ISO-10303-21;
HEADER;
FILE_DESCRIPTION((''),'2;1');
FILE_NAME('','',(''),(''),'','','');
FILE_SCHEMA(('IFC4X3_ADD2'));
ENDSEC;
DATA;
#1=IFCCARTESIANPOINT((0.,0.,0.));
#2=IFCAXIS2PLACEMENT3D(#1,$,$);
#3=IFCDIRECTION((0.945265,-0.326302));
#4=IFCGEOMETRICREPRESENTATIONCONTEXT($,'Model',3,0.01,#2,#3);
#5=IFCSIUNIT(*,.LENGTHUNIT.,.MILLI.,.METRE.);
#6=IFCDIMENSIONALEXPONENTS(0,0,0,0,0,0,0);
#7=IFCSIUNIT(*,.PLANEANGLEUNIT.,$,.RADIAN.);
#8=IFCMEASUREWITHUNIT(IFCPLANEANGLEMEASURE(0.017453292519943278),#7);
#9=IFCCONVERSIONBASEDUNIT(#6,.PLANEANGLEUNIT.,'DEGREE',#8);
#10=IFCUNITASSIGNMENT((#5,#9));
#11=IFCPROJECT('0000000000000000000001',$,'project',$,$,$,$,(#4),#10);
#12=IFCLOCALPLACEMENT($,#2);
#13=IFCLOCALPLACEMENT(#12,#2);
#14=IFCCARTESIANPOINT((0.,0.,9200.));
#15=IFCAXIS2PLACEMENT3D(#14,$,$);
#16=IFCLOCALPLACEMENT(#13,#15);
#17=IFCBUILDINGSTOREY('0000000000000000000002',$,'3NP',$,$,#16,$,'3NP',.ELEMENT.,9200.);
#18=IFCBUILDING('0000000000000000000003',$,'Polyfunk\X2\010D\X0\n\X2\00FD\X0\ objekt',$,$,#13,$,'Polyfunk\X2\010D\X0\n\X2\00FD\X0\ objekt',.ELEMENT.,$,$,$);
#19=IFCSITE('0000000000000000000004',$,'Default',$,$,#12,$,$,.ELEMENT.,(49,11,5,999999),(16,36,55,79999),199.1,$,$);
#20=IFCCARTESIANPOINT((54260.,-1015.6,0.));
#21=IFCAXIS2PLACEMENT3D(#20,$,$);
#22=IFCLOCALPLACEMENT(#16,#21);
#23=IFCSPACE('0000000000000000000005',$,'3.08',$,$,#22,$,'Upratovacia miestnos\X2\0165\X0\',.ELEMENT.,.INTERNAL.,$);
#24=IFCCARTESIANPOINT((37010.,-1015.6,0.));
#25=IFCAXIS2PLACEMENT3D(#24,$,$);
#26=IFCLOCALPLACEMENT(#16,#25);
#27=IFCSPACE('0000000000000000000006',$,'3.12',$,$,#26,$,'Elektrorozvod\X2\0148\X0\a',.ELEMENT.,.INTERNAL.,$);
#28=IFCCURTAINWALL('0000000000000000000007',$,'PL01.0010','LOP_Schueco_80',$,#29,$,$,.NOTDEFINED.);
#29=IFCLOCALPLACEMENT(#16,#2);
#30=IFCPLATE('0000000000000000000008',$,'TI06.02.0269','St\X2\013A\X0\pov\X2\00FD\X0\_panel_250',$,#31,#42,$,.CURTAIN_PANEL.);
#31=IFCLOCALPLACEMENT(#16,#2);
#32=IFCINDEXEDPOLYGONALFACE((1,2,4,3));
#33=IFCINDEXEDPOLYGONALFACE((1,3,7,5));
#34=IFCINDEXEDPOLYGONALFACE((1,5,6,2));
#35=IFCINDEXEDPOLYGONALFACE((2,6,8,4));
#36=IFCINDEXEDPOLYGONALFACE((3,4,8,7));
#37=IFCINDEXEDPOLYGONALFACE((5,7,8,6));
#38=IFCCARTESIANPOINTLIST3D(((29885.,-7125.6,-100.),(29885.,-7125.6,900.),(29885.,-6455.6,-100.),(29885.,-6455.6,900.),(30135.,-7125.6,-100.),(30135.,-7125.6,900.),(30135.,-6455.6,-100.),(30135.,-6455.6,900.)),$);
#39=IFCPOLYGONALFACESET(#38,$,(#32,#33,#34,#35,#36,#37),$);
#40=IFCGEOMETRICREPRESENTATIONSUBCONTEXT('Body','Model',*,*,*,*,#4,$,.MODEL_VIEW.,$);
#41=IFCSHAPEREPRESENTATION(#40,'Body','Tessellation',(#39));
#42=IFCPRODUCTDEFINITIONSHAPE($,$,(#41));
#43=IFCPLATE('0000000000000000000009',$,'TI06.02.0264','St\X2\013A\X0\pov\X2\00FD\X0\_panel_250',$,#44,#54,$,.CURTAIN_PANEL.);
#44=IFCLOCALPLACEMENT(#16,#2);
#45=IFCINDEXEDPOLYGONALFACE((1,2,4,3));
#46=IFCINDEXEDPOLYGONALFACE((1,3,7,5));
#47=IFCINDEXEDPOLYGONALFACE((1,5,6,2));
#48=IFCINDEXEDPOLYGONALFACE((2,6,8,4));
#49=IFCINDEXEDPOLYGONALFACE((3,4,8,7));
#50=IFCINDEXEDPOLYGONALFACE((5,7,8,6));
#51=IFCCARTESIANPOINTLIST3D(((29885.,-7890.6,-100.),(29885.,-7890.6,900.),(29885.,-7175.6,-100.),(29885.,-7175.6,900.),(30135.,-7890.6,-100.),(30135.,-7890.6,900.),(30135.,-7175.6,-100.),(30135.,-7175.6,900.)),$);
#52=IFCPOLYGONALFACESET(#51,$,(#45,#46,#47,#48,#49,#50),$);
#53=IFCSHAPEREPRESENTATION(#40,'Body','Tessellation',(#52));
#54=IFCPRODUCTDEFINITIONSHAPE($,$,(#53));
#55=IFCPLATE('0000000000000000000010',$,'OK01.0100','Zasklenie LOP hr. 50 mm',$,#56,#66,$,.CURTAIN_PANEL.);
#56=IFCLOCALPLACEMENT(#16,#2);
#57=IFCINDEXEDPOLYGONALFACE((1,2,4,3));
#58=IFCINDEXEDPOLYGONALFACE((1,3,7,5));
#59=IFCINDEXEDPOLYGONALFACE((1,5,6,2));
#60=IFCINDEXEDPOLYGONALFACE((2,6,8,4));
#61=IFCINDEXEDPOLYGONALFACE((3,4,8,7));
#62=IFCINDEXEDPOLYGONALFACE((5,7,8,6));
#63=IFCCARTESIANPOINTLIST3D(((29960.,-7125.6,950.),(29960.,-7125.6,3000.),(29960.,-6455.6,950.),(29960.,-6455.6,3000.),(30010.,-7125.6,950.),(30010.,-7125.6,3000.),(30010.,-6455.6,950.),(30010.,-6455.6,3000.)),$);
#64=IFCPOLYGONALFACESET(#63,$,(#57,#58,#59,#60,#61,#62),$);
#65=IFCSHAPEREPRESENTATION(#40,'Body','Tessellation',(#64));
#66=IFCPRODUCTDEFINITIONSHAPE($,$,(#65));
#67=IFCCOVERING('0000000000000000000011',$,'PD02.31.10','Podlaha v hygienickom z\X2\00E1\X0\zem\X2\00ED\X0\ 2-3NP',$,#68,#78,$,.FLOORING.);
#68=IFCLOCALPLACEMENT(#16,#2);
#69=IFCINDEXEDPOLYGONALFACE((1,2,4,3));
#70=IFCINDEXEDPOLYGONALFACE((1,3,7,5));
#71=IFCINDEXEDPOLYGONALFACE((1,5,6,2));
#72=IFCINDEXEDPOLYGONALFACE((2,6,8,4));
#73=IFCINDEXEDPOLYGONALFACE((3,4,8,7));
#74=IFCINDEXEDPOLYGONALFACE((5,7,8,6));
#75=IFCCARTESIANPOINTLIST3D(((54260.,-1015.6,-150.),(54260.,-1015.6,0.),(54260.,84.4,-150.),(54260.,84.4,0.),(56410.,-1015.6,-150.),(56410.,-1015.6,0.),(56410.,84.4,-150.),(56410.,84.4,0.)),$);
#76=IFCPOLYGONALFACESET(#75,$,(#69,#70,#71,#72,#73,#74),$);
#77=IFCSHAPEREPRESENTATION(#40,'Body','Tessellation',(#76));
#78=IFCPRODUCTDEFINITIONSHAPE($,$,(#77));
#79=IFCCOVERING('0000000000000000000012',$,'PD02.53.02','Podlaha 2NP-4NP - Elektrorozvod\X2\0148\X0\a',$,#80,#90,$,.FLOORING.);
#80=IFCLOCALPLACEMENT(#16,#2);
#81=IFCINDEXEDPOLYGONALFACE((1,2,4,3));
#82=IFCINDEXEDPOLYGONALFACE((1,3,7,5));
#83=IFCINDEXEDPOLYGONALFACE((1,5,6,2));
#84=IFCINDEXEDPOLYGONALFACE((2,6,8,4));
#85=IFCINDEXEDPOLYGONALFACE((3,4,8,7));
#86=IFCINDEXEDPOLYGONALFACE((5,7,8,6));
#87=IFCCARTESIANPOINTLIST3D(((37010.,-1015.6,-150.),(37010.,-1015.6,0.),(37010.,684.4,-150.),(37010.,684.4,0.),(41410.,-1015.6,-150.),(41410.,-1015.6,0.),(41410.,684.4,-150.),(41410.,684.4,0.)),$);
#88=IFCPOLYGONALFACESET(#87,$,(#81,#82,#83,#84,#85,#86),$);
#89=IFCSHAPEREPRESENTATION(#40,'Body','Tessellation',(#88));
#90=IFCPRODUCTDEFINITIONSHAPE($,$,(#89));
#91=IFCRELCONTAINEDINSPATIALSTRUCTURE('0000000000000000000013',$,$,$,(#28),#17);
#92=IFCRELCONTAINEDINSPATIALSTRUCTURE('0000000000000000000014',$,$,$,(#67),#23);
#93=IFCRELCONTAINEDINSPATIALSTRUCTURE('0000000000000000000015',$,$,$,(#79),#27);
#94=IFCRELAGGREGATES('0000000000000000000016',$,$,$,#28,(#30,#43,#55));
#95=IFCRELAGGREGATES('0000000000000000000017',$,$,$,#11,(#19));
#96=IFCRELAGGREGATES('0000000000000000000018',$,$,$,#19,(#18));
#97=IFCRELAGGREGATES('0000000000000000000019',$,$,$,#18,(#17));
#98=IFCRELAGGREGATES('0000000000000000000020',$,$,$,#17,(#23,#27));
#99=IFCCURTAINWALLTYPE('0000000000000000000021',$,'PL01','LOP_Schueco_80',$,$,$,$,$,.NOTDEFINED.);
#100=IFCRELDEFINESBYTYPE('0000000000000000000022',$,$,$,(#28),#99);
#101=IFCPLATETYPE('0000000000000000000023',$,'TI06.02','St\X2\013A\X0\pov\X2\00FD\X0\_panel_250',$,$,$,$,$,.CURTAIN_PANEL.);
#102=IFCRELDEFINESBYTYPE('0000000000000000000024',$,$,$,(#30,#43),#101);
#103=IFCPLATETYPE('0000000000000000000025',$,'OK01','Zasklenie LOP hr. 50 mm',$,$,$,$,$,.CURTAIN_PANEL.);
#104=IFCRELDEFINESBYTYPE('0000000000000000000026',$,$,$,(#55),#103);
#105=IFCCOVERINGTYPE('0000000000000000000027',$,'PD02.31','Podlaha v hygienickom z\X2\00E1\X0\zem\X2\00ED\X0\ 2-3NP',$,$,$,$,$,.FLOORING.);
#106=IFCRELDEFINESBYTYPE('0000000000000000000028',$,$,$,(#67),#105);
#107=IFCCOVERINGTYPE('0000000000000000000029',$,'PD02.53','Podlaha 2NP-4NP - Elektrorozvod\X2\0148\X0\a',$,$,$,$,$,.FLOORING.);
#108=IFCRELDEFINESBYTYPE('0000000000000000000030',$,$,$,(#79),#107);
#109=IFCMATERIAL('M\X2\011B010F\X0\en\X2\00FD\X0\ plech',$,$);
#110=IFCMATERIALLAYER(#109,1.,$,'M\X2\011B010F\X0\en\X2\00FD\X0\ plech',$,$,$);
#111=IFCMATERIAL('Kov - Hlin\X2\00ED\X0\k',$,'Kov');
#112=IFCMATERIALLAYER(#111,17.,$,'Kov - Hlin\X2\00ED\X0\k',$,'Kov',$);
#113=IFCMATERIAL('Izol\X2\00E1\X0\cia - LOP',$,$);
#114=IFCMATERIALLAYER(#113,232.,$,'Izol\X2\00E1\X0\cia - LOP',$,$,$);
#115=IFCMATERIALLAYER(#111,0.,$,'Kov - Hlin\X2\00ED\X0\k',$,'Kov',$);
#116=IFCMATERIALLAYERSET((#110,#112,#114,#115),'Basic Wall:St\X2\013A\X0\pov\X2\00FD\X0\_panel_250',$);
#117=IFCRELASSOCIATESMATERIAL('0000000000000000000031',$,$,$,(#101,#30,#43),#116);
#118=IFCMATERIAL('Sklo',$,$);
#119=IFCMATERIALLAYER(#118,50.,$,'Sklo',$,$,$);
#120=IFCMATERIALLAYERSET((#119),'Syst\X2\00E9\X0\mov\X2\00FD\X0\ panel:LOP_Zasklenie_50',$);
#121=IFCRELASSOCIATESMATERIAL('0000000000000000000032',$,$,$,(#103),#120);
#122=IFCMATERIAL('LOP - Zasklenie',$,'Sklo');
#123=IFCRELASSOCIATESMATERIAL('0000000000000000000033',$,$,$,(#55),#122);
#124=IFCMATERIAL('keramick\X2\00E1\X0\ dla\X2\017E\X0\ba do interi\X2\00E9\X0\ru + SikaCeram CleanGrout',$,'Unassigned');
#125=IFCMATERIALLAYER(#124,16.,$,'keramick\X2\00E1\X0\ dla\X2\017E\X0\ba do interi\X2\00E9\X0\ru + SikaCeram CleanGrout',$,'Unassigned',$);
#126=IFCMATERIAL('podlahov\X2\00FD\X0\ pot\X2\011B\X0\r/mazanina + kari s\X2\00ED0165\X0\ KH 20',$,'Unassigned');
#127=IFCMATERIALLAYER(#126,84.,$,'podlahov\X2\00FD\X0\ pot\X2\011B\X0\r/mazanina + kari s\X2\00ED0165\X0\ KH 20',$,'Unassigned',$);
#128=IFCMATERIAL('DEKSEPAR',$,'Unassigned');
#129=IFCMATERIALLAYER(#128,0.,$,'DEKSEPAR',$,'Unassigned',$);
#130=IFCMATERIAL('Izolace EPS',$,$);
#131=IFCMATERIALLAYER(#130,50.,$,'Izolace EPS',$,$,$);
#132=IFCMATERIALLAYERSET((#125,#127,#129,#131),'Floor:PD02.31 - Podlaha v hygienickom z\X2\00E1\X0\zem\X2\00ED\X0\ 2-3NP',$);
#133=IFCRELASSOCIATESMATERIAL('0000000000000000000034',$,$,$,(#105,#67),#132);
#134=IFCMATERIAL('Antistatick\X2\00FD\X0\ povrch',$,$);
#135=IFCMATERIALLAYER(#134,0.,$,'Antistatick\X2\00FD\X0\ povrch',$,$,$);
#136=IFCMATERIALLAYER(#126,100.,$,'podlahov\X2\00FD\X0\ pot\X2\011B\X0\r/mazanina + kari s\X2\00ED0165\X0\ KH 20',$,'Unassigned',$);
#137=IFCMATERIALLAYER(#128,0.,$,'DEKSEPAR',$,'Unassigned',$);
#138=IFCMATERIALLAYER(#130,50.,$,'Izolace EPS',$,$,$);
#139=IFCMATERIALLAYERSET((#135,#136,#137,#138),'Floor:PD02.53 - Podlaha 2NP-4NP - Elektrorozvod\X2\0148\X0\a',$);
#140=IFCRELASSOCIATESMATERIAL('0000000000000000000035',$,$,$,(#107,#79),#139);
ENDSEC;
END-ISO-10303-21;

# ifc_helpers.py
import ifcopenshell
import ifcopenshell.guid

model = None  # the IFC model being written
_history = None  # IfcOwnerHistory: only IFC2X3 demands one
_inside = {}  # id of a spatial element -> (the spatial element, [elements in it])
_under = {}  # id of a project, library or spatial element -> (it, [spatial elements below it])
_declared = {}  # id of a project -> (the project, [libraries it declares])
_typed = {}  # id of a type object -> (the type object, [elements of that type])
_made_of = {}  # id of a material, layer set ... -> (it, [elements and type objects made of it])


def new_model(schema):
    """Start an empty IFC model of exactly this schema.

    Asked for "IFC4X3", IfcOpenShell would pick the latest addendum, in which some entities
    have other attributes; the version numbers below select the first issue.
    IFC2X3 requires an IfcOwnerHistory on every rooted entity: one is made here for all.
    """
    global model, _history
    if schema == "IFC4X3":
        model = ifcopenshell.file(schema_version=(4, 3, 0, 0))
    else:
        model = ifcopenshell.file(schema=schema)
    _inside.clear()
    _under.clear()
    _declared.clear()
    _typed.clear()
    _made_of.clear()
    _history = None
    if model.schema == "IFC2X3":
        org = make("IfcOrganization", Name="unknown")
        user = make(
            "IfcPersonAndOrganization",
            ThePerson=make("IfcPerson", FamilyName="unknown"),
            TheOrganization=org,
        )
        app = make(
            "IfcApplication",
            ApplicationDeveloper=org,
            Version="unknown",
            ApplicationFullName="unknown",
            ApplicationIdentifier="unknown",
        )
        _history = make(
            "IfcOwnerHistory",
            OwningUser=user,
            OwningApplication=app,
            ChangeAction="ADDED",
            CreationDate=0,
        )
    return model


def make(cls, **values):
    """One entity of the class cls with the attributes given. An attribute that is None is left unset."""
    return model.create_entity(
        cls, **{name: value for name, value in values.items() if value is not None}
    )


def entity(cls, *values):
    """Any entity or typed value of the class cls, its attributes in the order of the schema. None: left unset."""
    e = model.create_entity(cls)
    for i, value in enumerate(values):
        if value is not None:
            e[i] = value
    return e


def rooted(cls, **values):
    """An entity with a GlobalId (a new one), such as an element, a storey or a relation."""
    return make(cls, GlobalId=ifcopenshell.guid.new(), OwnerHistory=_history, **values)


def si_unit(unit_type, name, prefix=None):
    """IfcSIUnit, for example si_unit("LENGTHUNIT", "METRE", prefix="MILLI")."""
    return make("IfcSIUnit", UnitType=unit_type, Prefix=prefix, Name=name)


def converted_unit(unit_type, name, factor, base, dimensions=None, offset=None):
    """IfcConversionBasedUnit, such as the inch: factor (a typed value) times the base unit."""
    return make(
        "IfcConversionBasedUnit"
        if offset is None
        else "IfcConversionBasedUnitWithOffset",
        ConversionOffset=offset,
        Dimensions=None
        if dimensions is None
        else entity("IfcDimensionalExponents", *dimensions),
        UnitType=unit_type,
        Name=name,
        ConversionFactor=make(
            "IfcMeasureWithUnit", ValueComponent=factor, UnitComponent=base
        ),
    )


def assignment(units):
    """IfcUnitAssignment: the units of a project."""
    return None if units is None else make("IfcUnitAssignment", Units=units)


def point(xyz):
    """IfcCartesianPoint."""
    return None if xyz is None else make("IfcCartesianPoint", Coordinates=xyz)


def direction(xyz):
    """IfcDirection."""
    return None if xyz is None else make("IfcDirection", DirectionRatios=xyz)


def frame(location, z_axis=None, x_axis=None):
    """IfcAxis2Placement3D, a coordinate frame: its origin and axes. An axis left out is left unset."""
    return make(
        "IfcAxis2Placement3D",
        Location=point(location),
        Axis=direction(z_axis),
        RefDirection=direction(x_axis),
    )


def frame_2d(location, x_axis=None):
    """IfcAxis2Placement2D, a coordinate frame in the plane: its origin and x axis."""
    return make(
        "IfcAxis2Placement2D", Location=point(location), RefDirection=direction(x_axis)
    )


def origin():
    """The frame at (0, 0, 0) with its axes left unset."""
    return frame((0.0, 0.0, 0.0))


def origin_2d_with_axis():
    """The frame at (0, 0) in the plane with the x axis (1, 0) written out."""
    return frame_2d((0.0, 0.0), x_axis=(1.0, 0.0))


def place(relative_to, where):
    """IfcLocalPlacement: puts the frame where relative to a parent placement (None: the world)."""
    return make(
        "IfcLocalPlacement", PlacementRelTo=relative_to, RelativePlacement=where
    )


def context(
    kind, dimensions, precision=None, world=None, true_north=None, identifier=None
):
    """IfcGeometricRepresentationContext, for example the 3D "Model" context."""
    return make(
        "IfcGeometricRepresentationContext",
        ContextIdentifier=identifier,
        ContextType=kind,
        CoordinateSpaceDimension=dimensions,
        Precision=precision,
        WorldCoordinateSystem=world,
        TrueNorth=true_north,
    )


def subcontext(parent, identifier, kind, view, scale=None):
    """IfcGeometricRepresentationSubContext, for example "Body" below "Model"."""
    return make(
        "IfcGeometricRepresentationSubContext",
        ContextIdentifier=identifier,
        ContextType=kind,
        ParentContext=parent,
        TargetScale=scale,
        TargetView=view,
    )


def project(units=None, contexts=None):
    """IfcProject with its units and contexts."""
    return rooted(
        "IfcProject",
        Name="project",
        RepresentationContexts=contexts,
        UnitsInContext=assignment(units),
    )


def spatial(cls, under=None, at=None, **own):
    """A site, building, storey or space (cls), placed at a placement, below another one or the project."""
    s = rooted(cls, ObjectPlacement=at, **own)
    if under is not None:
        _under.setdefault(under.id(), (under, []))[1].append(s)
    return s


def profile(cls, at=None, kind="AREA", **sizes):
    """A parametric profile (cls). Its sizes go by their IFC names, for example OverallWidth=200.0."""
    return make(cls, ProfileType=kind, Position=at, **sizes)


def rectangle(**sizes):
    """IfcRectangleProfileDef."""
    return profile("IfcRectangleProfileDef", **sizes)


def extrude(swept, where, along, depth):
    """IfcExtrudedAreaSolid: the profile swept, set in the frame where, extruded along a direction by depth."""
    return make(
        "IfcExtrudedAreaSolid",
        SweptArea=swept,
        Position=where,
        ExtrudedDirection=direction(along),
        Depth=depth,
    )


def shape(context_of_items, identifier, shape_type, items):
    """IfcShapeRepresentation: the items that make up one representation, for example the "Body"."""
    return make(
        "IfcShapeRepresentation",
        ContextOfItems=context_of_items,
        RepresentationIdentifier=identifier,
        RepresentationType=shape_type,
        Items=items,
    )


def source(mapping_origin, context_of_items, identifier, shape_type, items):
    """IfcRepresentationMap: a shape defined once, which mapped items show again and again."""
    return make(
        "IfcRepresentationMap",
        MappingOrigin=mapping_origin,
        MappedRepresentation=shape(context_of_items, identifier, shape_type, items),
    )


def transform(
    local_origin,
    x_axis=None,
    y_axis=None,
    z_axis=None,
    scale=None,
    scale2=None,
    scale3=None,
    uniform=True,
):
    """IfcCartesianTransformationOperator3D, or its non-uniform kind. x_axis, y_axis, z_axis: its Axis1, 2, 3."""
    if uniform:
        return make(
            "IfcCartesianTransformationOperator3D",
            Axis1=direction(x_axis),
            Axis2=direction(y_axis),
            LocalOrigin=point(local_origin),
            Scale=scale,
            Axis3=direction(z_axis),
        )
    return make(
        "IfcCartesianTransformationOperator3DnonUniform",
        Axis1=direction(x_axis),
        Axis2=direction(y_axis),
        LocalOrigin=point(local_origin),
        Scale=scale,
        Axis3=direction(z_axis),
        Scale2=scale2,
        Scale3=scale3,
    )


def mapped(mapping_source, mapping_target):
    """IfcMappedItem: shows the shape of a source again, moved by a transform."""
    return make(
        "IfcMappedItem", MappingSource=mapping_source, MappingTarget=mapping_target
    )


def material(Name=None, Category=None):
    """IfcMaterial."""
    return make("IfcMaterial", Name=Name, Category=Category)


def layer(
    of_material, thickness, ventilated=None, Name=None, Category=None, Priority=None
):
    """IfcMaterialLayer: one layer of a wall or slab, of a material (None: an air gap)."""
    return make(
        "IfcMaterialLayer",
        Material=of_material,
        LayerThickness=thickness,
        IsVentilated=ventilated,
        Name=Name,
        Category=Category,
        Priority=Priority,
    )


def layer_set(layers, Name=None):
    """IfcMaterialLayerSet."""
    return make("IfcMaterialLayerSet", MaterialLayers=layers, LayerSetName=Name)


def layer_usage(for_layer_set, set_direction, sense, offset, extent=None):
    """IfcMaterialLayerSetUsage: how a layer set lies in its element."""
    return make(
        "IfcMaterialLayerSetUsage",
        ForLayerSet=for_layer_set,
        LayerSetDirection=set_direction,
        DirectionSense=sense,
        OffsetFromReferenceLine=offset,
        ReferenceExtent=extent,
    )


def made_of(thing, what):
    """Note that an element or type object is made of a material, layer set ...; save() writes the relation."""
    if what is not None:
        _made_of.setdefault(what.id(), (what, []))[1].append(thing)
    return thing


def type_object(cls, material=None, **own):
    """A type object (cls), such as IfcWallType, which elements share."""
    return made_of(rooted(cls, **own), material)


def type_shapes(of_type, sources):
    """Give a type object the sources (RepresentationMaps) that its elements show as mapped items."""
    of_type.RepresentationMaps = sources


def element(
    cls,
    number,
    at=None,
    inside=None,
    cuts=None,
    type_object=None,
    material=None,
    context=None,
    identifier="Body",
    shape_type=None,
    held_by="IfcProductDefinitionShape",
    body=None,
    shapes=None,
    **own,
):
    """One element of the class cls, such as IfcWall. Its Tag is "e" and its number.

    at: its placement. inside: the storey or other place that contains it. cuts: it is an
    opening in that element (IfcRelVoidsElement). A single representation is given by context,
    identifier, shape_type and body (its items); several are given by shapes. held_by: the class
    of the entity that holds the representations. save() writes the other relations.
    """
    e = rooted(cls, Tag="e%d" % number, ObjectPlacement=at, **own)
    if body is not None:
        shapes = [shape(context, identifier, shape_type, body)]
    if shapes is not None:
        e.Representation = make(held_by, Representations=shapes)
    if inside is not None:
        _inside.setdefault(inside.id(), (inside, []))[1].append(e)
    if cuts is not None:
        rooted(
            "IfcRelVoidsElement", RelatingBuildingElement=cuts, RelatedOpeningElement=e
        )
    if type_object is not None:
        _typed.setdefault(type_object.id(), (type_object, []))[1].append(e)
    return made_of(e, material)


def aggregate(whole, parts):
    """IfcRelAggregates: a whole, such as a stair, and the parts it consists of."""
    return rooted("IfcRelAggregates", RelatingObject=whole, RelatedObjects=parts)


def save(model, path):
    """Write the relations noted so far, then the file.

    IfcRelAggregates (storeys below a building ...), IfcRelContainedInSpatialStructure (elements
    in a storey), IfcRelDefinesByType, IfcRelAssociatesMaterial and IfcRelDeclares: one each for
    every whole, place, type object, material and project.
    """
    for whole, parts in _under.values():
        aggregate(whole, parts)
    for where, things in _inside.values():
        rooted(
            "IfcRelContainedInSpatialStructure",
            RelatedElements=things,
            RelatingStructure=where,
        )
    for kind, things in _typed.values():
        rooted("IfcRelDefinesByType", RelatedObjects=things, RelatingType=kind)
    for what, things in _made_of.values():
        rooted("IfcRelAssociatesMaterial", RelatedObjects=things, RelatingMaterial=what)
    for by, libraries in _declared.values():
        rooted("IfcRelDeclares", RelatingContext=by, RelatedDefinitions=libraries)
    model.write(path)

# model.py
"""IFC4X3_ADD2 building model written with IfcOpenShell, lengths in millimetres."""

from ifc_helpers import new_model, entity, si_unit, converted_unit, direction, frame, frame_2d, origin, origin_2d_with_axis, place, context, subcontext, project, spatial, rectangle, extrude, source, transform, mapped, material, layer, layer_set, layer_usage, type_object, type_shapes, element, aggregate, save


model = new_model("IFC4X3_ADD2")

# Units and contexts
model_context = context("Model", 3, precision=0.01, world=origin(), true_north=direction((0.945265, -0.326302)))
body_context = subcontext(model_context, "Body", "Model", "MODEL_VIEW")
ifc_project = project(units=[si_unit("LENGTHUNIT", "METRE", prefix="MILLI"), converted_unit("PLANEANGLEUNIT", "DEGREE", entity("IfcPlaneAngleMeasure", 0.017453292519943278), si_unit("PLANEANGLEUNIT", "RADIAN"), dimensions=[0, 0, 0, 0, 0, 0, 0])], contexts=[model_context])

# Site, building, storey
site_placement = place(None, origin())
site = spatial("IfcSite", under=ifc_project, at=site_placement, Name="Default", CompositionType="ELEMENT", RefLatitude=(49, 11, 5, 999999), RefLongitude=(16, 36, 55, 79999), RefElevation=199.1)
building_placement = place(site_placement, origin())
building = spatial("IfcBuilding", under=site, at=building_placement, Name="Polyfunkčný objekt", LongName="Polyfunkčný objekt", CompositionType="ELEMENT")
storey_placement = place(building_placement, frame((0.0, 0.0, 9200.0)))
storey = spatial("IfcBuildingStorey", under=building, at=storey_placement, Name="3NP", LongName="3NP", CompositionType="ELEMENT", Elevation=9200.0)

# Shared definitions
curtain_wall_type = type_object("IfcCurtainWallType", Name="PL01", Description="LOP_Schueco_80", PredefinedType="NOTDEFINED")

# Curtain wall
curtain_wall_1_placement = place(storey_placement, frame((0.0, 0.0, -9200.0)))
curtain_wall_1 = element("IfcCurtainWall", 1, at=curtain_wall_1_placement, inside=storey, type_object=curtain_wall_type, Name="PL01.0010", Description="LOP_Schueco_80", PredefinedType="NOTDEFINED")

# Shared definitions
ifc_material_1 = material(Name="Měďený plech")
ifc_layer_1 = layer(ifc_material_1, 1.0, Name="Měďený plech")
ifc_material_2 = material(Name="Kov - Hliník", Category="Kov")
ifc_layer_2 = layer(ifc_material_2, 17.0, Name="Kov - Hliník", Category="Kov")
ifc_material_3 = material(Name="Izolácia - LOP")
ifc_layer_3 = layer(ifc_material_3, 232.0, Name="Izolácia - LOP")
ifc_layer_4 = layer(ifc_material_2, 0.0, Name="Kov - Hliník", Category="Kov")
ifc_layer_set_1 = layer_set([ifc_layer_1, ifc_layer_2, ifc_layer_3, ifc_layer_4], Name="Basic Wall:Stĺpový_panel_250")
plate_type_1 = type_object("IfcPlateType", Name="TI06.02", Description="Stĺpový_panel_250", PredefinedType="CURTAIN_PANEL", material=ifc_layer_set_1)

# Plates
ifc_layer_usage_1 = layer_usage(ifc_layer_set_1, "AXIS2", "POSITIVE", -125.0)
plate_1_placement = place(storey_placement, frame((30010.0, -6455.6, -100.0), z_axis=(0.0, 0.0, 1.0), x_axis=(0.0, -1.0, 0.0)))
plate_1 = element("IfcPlate", 2, at=plate_1_placement, type_object=plate_type_1, material=ifc_layer_usage_1, Name="TI06.02.0269", Description="Stĺpový_panel_250", PredefinedType="CURTAIN_PANEL", context=body_context, shape_type="SweptSolid", body=[
    extrude(rectangle(XDim=250.0, YDim=670.0, at=frame_2d((0.0, 0.0), x_axis=(1.0, 0.0))), frame((335.0, 0.0, 0.0), z_axis=(0.0, 0.0, 1.0), x_axis=(0.0, 1.0, 0.0)), (0.0, 0.0, 1.0), 1000.0),
])
ifc_layer_usage_2 = layer_usage(ifc_layer_set_1, "AXIS2", "POSITIVE", -125.0)
plate_2_placement = place(storey_placement, frame((30010.0, -7175.6, -100.0), z_axis=(0.0, 0.0, 1.0), x_axis=(0.0, -1.0, 0.0)))
plate_2 = element("IfcPlate", 3, at=plate_2_placement, type_object=plate_type_1, material=ifc_layer_usage_2, Name="TI06.02.0264", Description="Stĺpový_panel_250", PredefinedType="CURTAIN_PANEL", context=body_context, shape_type="SweptSolid", body=[
    extrude(rectangle(XDim=250.0, YDim=715.0, at=frame_2d((0.0, 0.0), x_axis=(1.0, 0.0))), frame((357.5, 0.0, 0.0), z_axis=(0.0, 0.0, 1.0), x_axis=(0.0, 1.0, 0.0)), (0.0, 0.0, 1.0), 1000.0),
])
ifc_material_4 = material(Name="LOP - Zasklenie", Category="Sklo")
ifc_material_5 = material(Name="Sklo")
ifc_layer_5 = layer(ifc_material_5, 50.0, Name="Sklo")
ifc_layer_set_2 = layer_set([ifc_layer_5], Name="Systémový panel:LOP_Zasklenie_50")
plate_type_2 = type_object("IfcPlateType", Name="OK01", Description="Zasklenie LOP hr. 50 mm", PredefinedType="CURTAIN_PANEL", material=ifc_layer_set_2)
shared_shape_1 = source(origin(), body_context, "Body", "SweptSolid", [
    extrude(rectangle(XDim=50.0, YDim=670.0, at=origin_2d_with_axis()), frame((0.0, -25.0, 0.0), z_axis=(0.0, 0.0, 1.0), x_axis=(0.0, 1.0, 0.0)), (0.0, 0.0, 1.0), 2050.0),
])
type_shapes(plate_type_2, [shared_shape_1])
plate_3_placement = place(curtain_wall_1_placement, frame((30010.0, -6790.6, 10150.0), z_axis=(0.0, 0.0, 1.0), x_axis=(0.0, -1.0, 0.0)))
plate_3 = element("IfcPlate", 4, at=plate_3_placement, type_object=plate_type_2, material=ifc_material_4, Name="OK01.0100", Description="Zasklenie LOP hr. 50 mm", PredefinedType="CURTAIN_PANEL", context=body_context, shape_type="MappedRepresentation", body=[
    mapped(shared_shape_1, transform((0.0, 0.0, 0.0), scale=1.0)),
])
aggregate(curtain_wall_1, [plate_1, plate_2, plate_3])

# Shared definitions
ifc_material_6 = material(Name="keramická dlažba do interiéru + SikaCeram CleanGrout", Category="Unassigned")
ifc_layer_6 = layer(ifc_material_6, 16.0, Name="keramická dlažba do interiéru + SikaCeram CleanGrout", Category="Unassigned")
ifc_material_7 = material(Name="podlahový potěr/mazanina + kari síť KH 20", Category="Unassigned")
ifc_layer_7 = layer(ifc_material_7, 84.0, Name="podlahový potěr/mazanina + kari síť KH 20", Category="Unassigned")
ifc_material_8 = material(Name="DEKSEPAR", Category="Unassigned")
ifc_layer_8 = layer(ifc_material_8, 0.0, Name="DEKSEPAR", Category="Unassigned")
ifc_material_9 = material(Name="Izolace EPS")
ifc_layer_9 = layer(ifc_material_9, 50.0, Name="Izolace EPS")
ifc_layer_set_3 = layer_set([ifc_layer_6, ifc_layer_7, ifc_layer_8, ifc_layer_9], Name="Floor:PD02.31 - Podlaha v hygienickom zázemí 2-3NP")
covering_type_1 = type_object("IfcCoveringType", Name="PD02.31", Description="Podlaha v hygienickom zázemí 2-3NP", PredefinedType="FLOORING", material=ifc_layer_set_3)

# Shared definitions
space_1_placement = place(storey_placement, frame((54260.0, -1015.6, 0.0)))
space_1 = spatial("IfcSpace", under=storey, at=space_1_placement, Name="3.08", LongName="Upratovacia miestnosť", CompositionType="ELEMENT", PredefinedType="INTERNAL")

# Covering
ifc_layer_usage_3 = layer_usage(ifc_layer_set_3, "AXIS3", "POSITIVE", 0.0)
covering_1_placement = place(storey_placement, origin())
element("IfcCovering", 5, at=covering_1_placement, inside=space_1, type_object=covering_type_1, material=ifc_layer_usage_3, Name="PD02.31.10", Description="Podlaha v hygienickom zázemí 2-3NP", PredefinedType="FLOORING", context=body_context, shape_type="SweptSolid", body=[
    extrude(rectangle(XDim=1100.0, YDim=2150.0, at=frame_2d((0.0, 0.0), x_axis=(1.0, 0.0))), frame((55335.0, -465.6, 0.0), z_axis=(0.0, 0.0, -1.0), x_axis=(0.0, 1.0, 0.0)), (0.0, 0.0, 1.0), 150.0),
])

# Shared definitions
space_2_placement = place(storey_placement, frame((37010.0, -1015.6, 0.0)))
space_2 = spatial("IfcSpace", under=storey, at=space_2_placement, Name="3.12", LongName="Elektrorozvodňa", CompositionType="ELEMENT", PredefinedType="INTERNAL")

# Covering
ifc_material_10 = material(Name="Antistatický povrch")
ifc_layer_10 = layer(ifc_material_10, 0.0, Name="Antistatický povrch")
ifc_layer_11 = layer(ifc_material_7, 100.0, Name="podlahový potěr/mazanina + kari síť KH 20", Category="Unassigned")
ifc_layer_12 = layer(ifc_material_8, 0.0, Name="DEKSEPAR", Category="Unassigned")
ifc_layer_13 = layer(ifc_material_9, 50.0, Name="Izolace EPS")
ifc_layer_set_4 = layer_set([ifc_layer_10, ifc_layer_11, ifc_layer_12, ifc_layer_13], Name="Floor:PD02.53 - Podlaha 2NP-4NP - Elektrorozvodňa")
ifc_layer_usage_4 = layer_usage(ifc_layer_set_4, "AXIS3", "POSITIVE", 0.0)
covering_type_2 = type_object("IfcCoveringType", Name="PD02.53", Description="Podlaha 2NP-4NP - Elektrorozvodňa", PredefinedType="FLOORING", material=ifc_layer_set_4)
covering_2_placement = place(storey_placement, origin())
element("IfcCovering", 6, at=covering_2_placement, inside=space_2, type_object=covering_type_2, material=ifc_layer_usage_4, Name="PD02.53.02", Description="Podlaha 2NP-4NP - Elektrorozvodňa", PredefinedType="FLOORING", context=body_context, shape_type="SweptSolid", body=[
    extrude(rectangle(XDim=1700.0, YDim=4400.0, at=frame_2d((0.0, 0.0), x_axis=(1.0, 0.0))), frame((39210.0, -165.6, 0.0), z_axis=(0.0, 0.0, -1.0), x_axis=(0.0, 1.0, 0.0)), (0.0, 0.0, 1.0), 150.0),
])

save(model, "model.ifc")
